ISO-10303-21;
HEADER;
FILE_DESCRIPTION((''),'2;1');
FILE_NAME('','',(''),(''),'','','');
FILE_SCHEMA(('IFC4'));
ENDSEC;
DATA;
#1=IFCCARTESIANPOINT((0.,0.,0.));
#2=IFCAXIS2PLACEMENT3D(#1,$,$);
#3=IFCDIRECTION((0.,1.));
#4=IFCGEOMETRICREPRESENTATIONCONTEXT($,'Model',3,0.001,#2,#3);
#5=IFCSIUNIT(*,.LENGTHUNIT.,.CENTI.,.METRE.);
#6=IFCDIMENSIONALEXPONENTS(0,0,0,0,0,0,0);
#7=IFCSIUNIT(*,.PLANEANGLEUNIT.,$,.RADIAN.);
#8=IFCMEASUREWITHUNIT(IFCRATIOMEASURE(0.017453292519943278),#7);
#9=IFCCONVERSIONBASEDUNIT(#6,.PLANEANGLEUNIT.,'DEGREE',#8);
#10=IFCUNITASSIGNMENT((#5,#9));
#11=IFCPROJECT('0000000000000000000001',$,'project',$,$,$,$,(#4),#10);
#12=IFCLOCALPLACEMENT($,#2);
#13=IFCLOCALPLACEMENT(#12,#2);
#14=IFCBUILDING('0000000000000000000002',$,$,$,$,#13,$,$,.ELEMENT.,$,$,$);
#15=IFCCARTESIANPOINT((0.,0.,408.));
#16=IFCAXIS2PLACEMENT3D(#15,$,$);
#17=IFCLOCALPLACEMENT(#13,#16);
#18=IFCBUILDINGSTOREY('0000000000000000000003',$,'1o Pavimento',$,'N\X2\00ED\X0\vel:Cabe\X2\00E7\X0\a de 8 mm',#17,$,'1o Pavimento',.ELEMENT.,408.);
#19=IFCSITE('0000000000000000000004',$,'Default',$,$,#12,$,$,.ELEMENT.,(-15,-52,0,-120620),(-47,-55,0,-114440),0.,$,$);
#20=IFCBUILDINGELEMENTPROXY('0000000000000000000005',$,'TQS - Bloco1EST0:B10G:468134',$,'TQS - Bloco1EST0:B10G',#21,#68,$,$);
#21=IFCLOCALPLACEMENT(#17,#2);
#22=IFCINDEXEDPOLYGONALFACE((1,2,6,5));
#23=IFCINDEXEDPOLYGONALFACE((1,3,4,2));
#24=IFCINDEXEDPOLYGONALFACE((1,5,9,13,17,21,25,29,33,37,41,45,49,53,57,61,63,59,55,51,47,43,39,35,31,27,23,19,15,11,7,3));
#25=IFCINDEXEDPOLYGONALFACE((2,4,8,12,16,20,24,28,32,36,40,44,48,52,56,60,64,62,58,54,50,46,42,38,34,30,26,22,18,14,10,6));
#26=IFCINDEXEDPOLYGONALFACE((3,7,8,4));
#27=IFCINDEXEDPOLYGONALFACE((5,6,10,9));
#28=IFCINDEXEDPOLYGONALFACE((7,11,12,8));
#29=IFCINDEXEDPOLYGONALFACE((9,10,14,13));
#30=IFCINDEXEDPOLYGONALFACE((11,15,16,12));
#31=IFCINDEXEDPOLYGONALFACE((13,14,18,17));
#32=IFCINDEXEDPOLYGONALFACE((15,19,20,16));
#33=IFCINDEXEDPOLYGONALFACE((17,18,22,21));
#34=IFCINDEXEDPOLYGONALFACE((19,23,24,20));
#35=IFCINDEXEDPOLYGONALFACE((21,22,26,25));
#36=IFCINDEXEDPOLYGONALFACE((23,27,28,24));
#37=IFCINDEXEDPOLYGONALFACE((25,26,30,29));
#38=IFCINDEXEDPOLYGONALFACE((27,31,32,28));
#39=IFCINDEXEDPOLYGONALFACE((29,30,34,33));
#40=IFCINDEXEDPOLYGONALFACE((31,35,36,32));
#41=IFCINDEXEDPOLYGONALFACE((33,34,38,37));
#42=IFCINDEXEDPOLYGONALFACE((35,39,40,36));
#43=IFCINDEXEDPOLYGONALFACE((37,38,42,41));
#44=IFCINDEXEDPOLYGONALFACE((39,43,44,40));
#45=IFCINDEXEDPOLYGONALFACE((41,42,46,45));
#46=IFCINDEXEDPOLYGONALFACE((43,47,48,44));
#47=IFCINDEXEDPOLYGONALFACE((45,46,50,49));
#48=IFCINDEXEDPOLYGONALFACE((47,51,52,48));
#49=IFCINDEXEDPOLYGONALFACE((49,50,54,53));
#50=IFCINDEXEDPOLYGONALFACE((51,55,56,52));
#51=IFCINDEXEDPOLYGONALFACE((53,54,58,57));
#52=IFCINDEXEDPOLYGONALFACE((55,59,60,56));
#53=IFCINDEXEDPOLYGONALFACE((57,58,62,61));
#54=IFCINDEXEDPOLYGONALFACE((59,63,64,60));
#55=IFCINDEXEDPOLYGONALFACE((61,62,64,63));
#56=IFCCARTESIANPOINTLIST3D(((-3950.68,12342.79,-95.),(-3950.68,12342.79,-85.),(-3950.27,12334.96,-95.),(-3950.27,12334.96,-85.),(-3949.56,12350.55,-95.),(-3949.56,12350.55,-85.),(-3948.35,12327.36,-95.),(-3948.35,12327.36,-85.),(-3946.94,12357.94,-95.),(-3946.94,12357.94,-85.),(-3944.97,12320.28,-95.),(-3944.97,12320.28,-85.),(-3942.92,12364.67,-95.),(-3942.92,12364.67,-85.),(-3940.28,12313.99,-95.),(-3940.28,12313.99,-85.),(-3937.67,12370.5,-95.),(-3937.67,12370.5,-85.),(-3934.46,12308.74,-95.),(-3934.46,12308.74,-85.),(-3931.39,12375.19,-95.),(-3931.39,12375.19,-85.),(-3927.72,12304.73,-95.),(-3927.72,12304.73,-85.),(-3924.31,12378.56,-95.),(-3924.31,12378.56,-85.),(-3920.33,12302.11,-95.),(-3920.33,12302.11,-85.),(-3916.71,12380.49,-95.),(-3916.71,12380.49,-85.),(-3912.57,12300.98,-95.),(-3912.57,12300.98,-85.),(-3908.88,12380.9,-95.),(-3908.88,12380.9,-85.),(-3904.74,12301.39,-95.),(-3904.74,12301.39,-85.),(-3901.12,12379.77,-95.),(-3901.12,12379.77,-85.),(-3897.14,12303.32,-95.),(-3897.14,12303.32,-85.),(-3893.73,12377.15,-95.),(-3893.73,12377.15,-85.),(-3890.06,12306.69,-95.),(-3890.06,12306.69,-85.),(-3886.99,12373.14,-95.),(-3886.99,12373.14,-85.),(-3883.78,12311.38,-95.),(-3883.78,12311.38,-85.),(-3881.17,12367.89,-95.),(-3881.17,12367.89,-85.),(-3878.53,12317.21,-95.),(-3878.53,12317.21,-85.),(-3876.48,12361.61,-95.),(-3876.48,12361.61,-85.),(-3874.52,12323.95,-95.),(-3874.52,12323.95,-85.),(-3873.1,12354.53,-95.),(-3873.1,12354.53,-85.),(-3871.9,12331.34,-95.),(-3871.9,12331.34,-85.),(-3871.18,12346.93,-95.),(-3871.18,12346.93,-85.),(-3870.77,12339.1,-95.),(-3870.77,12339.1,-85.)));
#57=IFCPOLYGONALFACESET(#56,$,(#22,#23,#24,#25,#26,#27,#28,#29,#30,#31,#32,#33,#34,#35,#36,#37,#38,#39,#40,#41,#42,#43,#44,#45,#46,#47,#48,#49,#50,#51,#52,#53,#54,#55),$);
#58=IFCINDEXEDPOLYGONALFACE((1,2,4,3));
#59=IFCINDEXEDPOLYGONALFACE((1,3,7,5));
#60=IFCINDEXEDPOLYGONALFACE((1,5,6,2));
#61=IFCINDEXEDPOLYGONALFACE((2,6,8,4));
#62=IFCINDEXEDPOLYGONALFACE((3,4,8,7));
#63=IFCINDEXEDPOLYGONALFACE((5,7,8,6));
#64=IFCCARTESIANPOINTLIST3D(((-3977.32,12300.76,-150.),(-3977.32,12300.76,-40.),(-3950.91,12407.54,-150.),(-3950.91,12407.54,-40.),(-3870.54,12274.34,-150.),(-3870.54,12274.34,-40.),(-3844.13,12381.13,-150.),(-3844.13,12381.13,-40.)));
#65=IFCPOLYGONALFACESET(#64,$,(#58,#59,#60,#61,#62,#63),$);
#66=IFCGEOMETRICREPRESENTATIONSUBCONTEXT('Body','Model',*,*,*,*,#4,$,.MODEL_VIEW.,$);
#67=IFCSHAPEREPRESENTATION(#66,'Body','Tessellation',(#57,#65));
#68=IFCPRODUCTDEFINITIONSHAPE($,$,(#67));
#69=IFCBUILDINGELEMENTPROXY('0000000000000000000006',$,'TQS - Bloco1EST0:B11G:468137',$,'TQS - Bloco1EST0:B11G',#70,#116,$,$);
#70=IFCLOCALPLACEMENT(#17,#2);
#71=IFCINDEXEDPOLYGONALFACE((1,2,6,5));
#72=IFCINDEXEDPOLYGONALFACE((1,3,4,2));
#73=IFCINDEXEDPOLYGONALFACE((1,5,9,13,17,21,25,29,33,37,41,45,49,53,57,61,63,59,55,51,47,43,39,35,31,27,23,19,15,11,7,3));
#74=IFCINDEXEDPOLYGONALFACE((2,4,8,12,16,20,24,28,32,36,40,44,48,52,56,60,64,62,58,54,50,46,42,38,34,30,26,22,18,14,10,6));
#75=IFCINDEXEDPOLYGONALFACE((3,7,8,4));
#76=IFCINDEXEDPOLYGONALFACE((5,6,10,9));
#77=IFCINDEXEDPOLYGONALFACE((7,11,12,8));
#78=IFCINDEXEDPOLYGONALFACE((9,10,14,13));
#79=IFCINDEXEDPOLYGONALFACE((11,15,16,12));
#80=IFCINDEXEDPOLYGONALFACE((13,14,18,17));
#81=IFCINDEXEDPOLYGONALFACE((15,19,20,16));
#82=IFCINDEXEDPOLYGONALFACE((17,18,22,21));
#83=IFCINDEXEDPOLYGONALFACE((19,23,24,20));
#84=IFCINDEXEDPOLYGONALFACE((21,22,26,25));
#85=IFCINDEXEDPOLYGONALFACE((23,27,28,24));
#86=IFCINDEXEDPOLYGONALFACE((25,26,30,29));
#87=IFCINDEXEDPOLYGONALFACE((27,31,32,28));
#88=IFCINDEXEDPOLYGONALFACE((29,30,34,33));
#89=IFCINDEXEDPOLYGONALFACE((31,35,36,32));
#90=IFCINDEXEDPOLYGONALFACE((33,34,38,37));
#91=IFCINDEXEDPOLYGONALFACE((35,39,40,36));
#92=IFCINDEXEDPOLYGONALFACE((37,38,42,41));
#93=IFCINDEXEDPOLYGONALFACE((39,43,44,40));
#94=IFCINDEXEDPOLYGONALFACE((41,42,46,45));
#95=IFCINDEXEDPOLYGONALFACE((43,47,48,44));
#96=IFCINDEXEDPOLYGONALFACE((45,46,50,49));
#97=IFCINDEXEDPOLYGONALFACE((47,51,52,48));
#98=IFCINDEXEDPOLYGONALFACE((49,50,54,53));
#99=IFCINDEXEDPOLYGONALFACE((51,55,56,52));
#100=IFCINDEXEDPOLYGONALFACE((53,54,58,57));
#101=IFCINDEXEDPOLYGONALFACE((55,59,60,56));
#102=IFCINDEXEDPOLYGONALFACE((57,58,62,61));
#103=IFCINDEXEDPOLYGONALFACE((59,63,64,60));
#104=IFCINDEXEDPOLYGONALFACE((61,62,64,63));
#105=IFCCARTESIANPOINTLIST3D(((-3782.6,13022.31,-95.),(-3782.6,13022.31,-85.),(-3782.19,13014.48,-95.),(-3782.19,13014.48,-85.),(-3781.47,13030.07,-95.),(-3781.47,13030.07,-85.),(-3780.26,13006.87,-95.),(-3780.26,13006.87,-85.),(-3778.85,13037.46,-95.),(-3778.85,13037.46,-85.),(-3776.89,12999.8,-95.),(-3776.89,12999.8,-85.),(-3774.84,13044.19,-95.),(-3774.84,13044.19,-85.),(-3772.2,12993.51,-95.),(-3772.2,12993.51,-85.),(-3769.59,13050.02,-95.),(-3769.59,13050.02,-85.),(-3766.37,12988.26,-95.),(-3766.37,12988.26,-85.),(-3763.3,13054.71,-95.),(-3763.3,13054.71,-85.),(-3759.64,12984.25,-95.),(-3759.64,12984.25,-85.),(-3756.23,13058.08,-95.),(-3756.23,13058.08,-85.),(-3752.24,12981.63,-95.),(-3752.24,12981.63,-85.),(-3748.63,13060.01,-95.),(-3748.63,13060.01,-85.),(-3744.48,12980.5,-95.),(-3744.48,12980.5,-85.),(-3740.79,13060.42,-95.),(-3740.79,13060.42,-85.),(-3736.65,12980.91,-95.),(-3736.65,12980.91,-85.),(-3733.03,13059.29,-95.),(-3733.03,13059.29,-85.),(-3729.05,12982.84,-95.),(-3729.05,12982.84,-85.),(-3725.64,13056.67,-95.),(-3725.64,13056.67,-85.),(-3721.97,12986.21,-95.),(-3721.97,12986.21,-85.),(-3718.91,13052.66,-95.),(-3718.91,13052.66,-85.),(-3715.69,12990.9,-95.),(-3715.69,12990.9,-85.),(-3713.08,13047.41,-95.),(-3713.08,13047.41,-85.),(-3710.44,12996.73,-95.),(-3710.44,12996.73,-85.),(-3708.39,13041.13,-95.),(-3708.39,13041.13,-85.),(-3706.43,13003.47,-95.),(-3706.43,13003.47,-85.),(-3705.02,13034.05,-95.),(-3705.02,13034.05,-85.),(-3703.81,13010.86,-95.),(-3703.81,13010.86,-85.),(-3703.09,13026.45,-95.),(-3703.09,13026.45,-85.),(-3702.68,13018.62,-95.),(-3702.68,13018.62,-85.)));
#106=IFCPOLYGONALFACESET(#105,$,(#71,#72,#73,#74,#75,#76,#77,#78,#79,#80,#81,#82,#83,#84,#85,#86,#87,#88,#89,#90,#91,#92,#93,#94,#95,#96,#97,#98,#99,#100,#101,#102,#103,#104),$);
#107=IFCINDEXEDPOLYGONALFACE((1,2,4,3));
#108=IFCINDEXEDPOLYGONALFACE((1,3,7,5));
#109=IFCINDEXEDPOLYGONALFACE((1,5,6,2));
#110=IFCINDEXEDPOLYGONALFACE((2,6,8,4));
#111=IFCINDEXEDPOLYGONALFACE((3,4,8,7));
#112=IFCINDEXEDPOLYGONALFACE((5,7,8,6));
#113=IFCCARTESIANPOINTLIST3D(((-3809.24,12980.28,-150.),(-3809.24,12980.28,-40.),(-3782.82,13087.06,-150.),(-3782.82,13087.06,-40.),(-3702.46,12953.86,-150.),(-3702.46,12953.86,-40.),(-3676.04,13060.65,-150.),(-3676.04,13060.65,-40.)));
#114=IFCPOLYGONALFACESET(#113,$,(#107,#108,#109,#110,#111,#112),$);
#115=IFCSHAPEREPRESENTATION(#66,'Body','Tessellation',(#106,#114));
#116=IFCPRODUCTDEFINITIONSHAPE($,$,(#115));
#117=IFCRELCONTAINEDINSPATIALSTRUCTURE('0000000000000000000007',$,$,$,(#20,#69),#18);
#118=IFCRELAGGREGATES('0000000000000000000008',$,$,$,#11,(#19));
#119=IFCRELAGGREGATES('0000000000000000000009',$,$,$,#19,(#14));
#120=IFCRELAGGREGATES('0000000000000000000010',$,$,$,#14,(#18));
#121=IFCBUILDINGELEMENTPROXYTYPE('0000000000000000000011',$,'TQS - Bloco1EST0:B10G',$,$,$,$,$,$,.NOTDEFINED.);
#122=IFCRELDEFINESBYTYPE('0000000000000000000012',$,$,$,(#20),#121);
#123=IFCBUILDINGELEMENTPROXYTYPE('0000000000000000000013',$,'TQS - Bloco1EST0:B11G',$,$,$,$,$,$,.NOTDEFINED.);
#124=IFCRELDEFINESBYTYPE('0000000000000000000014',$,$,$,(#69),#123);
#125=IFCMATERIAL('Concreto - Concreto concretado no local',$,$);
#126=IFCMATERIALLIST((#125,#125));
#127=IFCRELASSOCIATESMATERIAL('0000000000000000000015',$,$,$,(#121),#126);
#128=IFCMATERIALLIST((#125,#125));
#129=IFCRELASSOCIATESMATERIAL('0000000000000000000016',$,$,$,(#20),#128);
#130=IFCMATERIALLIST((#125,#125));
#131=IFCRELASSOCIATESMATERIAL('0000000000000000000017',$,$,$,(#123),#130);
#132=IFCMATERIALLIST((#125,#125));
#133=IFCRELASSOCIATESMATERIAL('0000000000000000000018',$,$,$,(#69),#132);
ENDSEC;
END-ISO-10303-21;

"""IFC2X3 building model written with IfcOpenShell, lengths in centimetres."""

from ifc_helpers import new_model, entity, si_unit, converted_unit, direction, frame, frame_2d, origin, origin_2d_with_axis, place, context, subcontext, project, spatial, rectangle, circle, extrude, source, transform, mapped, material, material_list, type_object, type_shapes, element, save


model = new_model("IFC2X3")

# Units and contexts
model_context = context("Model", 3, precision=0.001, world=origin(), true_north=direction((0.0, 1.0)))
body_context = subcontext(model_context, "Body", "Model", "MODEL_VIEW")
ifc_project = project(units=[si_unit("LENGTHUNIT", "METRE", prefix="CENTI"), converted_unit("PLANEANGLEUNIT", "DEGREE", entity("IfcRatioMeasure", 0.017453292519943278), si_unit("PLANEANGLEUNIT", "RADIAN"), dimensions=[0, 0, 0, 0, 0, 0, 0])], contexts=[model_context])

# Site, building, storey
site_placement = place(None, origin())
site = spatial("IfcSite", under=ifc_project, at=site_placement, Name="Default", CompositionType="ELEMENT", RefLatitude=(-15, -52, 0, -120620), RefLongitude=(-47, -55, 0, -114440), RefElevation=0.0)
building_placement = place(site_placement, origin())
building = spatial("IfcBuilding", under=site, at=building_placement, CompositionType="ELEMENT")
storey_placement = place(building_placement, frame((0.0, 0.0, 408.0)))
storey = spatial("IfcBuildingStorey", under=building, at=storey_placement, Name="1o Pavimento", ObjectType="Nível:Cabeça de 8 mm", LongName="1o Pavimento", CompositionType="ELEMENT", Elevation=408.0)

# Building element proxies
ifc_material_1 = material(Name="Concreto - Concreto concretado no local")
ifc_material_list_1 = material_list([ifc_material_1, ifc_material_1])
ifc_material_list_2 = material_list([ifc_material_1, ifc_material_1])
building_element_proxy_type_1 = type_object("IfcBuildingElementProxyType", Name="TQS - Bloco1EST0:B10G", PredefinedType="NOTDEFINED", material=ifc_material_list_2)
shared_shape_1 = source(origin(), body_context, "Body", "SweptSolid", [
    extrude(circle(Radius=40.0, at=frame_2d((0.0, 0.0), x_axis=(1.0, 0.0))), frame((0.0, 0.0, -55.0)), (0.0, 0.0, 1.0), 10.0),
    extrude(rectangle(XDim=110.0, YDim=110.0, at=origin_2d_with_axis()), frame((0.0, 0.0, -110.0), z_axis=(0.0, 0.0, 1.0), x_axis=(-1.0, 0.0, 0.0)), (0.0, 0.0, 1.0), 110.0),
])
type_shapes(building_element_proxy_type_1, [shared_shape_1])
proxy_1_placement = place(storey_placement, frame((-3910.73, 12340.94, -40.0), z_axis=(0.0, 0.0, 1.0), x_axis=(0.240122, 0.970743, 0.0)))
element("IfcBuildingElementProxy", 1, at=proxy_1_placement, inside=storey, type_object=building_element_proxy_type_1, material=ifc_material_list_1, Name="TQS - Bloco1EST0:B10G:468134", ObjectType="TQS - Bloco1EST0:B10G", context=body_context, shape_type="MappedRepresentation", body=[
    mapped(shared_shape_1, transform((0.0, 0.0, 0.0), scale=1.0)),
])
ifc_material_list_3 = material_list([ifc_material_1, ifc_material_1])
ifc_material_list_4 = material_list([ifc_material_1, ifc_material_1])
building_element_proxy_type_2 = type_object("IfcBuildingElementProxyType", Name="TQS - Bloco1EST0:B11G", PredefinedType="NOTDEFINED", material=ifc_material_list_4)
shared_shape_2 = source(origin(), body_context, "Body", "SweptSolid", [
    extrude(circle(Radius=40.0, at=frame_2d((0.0, 0.0), x_axis=(1.0, 0.0))), frame((0.0, 0.0, -55.0)), (0.0, 0.0, 1.0), 10.0),
    extrude(rectangle(XDim=110.0, YDim=110.0, at=origin_2d_with_axis()), frame((0.0, 0.0, -110.0), z_axis=(0.0, 0.0, 1.0), x_axis=(-1.0, 0.0, 0.0)), (0.0, 0.0, 1.0), 110.0),
])
type_shapes(building_element_proxy_type_2, [shared_shape_2])
proxy_2_placement = place(storey_placement, frame((-3742.64, 13020.46, -40.0), z_axis=(0.0, 0.0, 1.0), x_axis=(0.240122, 0.970743, 0.0)))
element("IfcBuildingElementProxy", 2, at=proxy_2_placement, inside=storey, type_object=building_element_proxy_type_2, material=ifc_material_list_3, Name="TQS - Bloco1EST0:B11G:468137", ObjectType="TQS - Bloco1EST0:B11G", context=body_context, shape_type="MappedRepresentation", body=[
    mapped(shared_shape_2, transform((0.0, 0.0, 0.0), scale=1.0)),
])

save(model, "model.ifc")
